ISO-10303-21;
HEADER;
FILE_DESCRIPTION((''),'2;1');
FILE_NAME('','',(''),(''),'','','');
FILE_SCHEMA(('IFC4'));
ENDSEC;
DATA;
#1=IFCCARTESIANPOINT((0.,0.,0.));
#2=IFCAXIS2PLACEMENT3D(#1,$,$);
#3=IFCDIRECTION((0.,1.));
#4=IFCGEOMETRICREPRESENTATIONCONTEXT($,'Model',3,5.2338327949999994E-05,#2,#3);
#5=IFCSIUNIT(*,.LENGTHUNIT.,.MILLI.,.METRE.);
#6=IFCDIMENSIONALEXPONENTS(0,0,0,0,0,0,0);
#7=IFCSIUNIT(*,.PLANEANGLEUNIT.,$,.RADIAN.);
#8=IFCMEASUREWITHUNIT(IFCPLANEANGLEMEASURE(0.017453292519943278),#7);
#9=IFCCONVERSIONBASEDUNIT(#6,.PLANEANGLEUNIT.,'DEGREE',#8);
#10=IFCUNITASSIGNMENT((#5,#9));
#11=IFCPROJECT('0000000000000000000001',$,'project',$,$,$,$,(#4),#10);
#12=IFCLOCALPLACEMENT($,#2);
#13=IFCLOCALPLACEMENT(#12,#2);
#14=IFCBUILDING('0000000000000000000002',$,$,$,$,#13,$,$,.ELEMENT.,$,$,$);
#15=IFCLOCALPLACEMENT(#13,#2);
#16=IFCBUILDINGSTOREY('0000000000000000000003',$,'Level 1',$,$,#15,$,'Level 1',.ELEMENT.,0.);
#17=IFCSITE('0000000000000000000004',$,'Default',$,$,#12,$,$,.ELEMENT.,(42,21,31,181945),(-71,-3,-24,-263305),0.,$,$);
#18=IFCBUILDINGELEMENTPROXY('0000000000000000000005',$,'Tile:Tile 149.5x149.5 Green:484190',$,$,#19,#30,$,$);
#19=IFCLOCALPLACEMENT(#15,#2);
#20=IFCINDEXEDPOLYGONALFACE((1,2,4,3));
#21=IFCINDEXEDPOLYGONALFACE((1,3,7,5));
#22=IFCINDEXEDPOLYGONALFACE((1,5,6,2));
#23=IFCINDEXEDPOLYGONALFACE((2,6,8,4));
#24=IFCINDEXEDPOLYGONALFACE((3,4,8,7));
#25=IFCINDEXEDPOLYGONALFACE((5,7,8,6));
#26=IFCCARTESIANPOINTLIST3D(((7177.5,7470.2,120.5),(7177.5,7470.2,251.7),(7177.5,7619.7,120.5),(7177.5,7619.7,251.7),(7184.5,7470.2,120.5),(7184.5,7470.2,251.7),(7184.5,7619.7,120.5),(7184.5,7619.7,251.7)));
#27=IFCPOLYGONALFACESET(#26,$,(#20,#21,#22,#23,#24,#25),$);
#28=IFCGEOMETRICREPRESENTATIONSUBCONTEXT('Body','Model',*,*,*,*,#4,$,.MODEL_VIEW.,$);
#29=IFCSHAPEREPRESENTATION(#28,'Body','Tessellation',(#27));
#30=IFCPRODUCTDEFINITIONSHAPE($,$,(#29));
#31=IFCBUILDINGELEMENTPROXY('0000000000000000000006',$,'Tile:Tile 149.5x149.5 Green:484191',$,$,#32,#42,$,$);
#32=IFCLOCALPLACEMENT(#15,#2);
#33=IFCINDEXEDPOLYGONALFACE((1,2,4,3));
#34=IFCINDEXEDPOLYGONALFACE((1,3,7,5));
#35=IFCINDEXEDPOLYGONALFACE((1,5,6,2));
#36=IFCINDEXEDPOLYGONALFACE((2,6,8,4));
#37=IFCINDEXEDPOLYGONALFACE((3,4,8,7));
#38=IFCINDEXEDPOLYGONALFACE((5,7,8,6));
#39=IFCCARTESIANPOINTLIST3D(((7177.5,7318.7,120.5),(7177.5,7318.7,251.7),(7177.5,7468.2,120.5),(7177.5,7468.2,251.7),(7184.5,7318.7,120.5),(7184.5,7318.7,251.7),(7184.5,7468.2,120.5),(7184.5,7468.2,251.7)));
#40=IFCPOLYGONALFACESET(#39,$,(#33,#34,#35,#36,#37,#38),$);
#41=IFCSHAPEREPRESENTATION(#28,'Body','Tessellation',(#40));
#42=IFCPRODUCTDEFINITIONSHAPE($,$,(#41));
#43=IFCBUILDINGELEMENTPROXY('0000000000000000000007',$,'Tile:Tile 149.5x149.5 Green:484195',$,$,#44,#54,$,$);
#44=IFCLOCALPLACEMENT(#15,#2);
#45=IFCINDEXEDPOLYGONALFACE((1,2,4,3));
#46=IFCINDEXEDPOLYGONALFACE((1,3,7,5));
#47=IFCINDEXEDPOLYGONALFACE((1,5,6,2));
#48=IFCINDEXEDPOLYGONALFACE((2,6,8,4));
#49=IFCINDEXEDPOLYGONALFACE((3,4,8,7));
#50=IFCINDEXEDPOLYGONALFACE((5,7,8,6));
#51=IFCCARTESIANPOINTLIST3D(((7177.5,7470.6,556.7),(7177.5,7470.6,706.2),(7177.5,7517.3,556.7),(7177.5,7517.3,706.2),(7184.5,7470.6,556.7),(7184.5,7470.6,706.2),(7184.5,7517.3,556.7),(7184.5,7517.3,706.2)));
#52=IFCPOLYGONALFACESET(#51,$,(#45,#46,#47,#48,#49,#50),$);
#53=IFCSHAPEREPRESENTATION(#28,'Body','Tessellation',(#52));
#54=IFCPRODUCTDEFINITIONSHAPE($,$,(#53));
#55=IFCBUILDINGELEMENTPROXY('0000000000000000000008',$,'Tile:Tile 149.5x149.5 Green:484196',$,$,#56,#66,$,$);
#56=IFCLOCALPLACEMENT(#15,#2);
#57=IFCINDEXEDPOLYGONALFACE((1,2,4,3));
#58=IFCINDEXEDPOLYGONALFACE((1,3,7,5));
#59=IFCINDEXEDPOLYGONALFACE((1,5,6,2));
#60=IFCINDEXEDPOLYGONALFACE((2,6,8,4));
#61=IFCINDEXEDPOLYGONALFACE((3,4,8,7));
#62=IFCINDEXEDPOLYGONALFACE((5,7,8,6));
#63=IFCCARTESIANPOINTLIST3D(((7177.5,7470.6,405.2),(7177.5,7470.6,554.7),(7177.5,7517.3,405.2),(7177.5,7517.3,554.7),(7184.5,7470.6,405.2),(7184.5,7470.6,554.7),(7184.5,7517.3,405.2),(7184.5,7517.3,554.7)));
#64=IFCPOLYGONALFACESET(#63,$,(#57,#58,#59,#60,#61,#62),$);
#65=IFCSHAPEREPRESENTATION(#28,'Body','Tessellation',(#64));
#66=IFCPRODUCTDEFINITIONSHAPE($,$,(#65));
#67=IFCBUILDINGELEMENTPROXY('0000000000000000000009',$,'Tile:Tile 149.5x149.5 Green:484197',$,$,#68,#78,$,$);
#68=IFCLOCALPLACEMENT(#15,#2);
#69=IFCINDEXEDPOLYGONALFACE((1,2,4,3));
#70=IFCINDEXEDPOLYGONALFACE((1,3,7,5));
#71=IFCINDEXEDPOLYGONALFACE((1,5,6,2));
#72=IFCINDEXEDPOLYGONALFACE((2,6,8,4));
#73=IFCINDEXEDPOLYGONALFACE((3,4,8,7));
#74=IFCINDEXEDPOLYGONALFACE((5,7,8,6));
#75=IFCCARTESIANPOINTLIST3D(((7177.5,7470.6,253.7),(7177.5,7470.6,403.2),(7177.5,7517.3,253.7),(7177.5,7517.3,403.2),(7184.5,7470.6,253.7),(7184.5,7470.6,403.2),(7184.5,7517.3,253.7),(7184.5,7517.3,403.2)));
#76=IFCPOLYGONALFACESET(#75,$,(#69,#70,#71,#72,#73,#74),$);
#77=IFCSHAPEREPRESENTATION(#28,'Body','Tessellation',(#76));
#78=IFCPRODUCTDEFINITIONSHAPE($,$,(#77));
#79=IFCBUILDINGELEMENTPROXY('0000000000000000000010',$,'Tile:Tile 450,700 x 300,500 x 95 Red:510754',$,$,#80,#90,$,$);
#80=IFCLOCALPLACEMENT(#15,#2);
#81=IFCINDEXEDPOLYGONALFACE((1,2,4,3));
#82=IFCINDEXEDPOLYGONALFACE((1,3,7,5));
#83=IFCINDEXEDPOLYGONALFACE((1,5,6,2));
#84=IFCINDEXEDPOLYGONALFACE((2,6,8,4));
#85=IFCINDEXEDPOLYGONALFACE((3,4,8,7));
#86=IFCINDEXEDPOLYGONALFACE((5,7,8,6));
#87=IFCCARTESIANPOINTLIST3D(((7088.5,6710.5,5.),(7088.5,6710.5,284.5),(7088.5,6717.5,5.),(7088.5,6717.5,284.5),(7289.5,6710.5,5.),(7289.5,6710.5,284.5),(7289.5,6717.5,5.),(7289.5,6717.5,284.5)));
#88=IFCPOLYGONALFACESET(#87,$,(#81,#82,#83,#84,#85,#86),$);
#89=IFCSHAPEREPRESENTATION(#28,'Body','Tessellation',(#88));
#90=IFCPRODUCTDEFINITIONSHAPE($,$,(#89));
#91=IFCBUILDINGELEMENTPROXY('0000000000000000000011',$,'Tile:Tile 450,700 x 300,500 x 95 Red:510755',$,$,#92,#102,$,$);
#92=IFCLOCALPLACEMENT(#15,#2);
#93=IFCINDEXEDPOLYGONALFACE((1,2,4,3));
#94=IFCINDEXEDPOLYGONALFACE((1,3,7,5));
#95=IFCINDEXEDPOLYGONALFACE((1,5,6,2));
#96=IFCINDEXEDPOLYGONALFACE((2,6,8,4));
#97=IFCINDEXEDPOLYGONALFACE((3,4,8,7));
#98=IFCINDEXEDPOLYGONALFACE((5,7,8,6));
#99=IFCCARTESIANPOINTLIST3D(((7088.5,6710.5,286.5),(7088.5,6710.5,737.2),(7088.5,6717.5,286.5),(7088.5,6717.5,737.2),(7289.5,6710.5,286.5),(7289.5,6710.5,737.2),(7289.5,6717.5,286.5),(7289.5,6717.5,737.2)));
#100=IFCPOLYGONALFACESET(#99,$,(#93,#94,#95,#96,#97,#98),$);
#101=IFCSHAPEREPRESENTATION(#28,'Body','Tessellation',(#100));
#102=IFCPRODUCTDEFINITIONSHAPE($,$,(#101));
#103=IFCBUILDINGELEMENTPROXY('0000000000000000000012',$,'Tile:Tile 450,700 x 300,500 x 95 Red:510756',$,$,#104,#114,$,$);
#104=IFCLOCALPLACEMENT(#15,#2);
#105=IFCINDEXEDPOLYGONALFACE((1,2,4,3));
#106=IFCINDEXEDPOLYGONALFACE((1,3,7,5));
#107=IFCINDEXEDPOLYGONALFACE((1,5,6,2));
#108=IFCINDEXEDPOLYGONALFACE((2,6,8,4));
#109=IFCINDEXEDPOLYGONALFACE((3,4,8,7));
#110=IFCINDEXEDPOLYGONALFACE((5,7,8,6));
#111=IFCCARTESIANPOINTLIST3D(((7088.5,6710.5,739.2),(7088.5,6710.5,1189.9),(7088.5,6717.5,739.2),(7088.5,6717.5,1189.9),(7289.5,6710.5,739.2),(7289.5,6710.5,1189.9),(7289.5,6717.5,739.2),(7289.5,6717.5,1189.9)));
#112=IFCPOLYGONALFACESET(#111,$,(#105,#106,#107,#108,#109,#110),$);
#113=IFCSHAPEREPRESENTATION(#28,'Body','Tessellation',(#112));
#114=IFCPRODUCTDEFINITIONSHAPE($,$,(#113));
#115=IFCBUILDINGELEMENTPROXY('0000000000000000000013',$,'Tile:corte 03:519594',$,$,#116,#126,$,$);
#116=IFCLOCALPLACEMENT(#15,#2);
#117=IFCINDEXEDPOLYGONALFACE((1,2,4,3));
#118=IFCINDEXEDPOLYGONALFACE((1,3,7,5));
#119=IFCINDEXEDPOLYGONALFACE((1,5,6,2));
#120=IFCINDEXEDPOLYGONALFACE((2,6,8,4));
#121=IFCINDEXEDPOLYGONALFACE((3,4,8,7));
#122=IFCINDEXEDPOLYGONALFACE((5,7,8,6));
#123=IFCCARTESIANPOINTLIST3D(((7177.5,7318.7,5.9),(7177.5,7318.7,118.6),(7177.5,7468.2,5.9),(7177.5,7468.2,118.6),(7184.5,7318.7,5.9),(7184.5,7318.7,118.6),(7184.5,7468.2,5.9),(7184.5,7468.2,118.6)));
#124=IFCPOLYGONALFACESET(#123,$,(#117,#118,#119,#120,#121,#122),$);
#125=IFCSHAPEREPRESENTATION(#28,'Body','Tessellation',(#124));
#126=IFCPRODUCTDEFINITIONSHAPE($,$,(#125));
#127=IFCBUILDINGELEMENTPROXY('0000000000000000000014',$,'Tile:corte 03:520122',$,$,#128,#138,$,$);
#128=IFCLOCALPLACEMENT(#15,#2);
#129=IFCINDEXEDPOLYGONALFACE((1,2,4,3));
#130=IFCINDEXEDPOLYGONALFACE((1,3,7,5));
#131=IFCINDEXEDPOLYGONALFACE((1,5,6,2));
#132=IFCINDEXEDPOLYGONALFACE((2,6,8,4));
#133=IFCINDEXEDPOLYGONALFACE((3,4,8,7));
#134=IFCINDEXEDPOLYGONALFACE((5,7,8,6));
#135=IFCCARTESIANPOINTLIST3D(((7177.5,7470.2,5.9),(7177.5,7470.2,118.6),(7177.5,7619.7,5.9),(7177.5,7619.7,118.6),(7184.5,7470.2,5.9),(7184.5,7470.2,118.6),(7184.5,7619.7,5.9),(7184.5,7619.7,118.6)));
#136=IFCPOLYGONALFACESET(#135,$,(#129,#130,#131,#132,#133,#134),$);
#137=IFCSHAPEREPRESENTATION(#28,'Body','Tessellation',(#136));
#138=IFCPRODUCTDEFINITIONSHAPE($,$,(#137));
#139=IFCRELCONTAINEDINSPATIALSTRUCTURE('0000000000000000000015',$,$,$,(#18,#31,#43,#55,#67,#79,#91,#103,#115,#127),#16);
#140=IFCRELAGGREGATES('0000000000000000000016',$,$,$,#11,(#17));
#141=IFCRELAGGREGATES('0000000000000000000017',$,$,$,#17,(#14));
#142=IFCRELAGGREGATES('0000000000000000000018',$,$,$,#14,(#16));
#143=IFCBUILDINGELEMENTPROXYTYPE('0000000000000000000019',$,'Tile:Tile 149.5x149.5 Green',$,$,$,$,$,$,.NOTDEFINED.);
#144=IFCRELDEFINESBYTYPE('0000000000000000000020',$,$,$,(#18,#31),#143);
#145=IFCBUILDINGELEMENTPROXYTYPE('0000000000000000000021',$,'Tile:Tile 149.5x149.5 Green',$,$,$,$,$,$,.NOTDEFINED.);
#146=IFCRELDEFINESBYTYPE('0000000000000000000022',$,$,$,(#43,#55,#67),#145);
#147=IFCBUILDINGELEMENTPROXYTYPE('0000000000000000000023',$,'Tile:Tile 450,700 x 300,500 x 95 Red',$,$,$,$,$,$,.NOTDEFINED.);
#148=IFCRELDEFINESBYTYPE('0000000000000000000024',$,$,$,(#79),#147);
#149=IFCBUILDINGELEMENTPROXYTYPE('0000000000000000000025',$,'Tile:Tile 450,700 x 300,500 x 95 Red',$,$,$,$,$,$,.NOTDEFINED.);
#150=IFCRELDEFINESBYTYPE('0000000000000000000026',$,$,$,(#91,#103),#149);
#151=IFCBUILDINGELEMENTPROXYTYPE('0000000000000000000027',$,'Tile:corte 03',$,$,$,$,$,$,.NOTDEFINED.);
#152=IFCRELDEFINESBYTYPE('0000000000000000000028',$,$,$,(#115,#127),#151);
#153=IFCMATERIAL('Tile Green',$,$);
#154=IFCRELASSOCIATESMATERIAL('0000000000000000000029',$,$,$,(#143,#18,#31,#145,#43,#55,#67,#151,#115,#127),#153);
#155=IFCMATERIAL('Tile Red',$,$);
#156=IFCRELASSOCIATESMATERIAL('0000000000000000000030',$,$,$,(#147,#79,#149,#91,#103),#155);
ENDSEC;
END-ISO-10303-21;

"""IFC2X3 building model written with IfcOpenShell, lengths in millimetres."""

from ifc_helpers import new_model, entity, si_unit, converted_unit, direction, frame, frame_2d, origin, origin_2d_with_axis, place, context, subcontext, project, spatial, rectangle, extrude, source, transform, mapped, material, type_object, type_shapes, element, save


model = new_model("IFC2X3")

# Units and contexts
model_context = context("Model", 3, precision=5.2338327949999994e-05, world=origin(), true_north=direction((0.0, 1.0)))
body_context = subcontext(model_context, "Body", "Model", "MODEL_VIEW")
ifc_project = project(units=[si_unit("LENGTHUNIT", "METRE", prefix="MILLI"), converted_unit("PLANEANGLEUNIT", "DEGREE", entity("IfcPlaneAngleMeasure", 0.017453292519943278), si_unit("PLANEANGLEUNIT", "RADIAN"), dimensions=[0, 0, 0, 0, 0, 0, 0])], contexts=[model_context])

# Site, building, storey
site_placement = place(None, origin())
site = spatial("IfcSite", under=ifc_project, at=site_placement, Name="Default", CompositionType="ELEMENT", RefLatitude=(42, 21, 31, 181945), RefLongitude=(-71, -3, -24, -263305), RefElevation=0.0)
building_placement = place(site_placement, origin())
building = spatial("IfcBuilding", under=site, at=building_placement, CompositionType="ELEMENT")
storey_placement = place(building_placement, origin())
storey = spatial("IfcBuildingStorey", under=building, at=storey_placement, Name="Level 1", LongName="Level 1", CompositionType="ELEMENT", Elevation=0.0)

# Building element proxies
ifc_material_1 = material(Name="Tile Red")
ifc_material_2 = material(Name="Tile Green")
building_element_proxy_type_1 = type_object("IfcBuildingElementProxyType", Name="Tile:Tile 149.5x149.5 Green", PredefinedType="NOTDEFINED", material=ifc_material_2)
shared_shape_1 = source(origin(), body_context, "Body", "SweptSolid", [
    extrude(rectangle(XDim=131.2, YDim=149.5, at=origin_2d_with_axis()), frame((-65.6, -74.8, 0.0), z_axis=(0.0, 0.0, 1.0), x_axis=(-1.0, 0.0, 0.0)), (0.0, 0.0, 1.0), 7.0),
])
type_shapes(building_element_proxy_type_1, [shared_shape_1])
for number, where, z_axis, x_axis, name in (
    (1, (7184.5, 7619.7, 251.7), (-1.0, 0.0, 0.0), (0.0, 0.0, 1.0), "Tile:Tile 149.5x149.5 Green:484190"),
    (2, (7184.5, 7468.2, 251.7), (-1.0, 0.0, 0.0), (0.0, 0.0, 1.0), "Tile:Tile 149.5x149.5 Green:484191"),
):
    element("IfcBuildingElementProxy", number, at=place(storey_placement, frame(where, z_axis=z_axis, x_axis=x_axis)), inside=storey, type_object=building_element_proxy_type_1, material=ifc_material_2, Name=name, context=body_context, shape_type="MappedRepresentation", body=[
        mapped(shared_shape_1, transform((0.0, 0.0, 0.0), scale=1.0)),
    ])
building_element_proxy_type_2 = type_object("IfcBuildingElementProxyType", Name="Tile:Tile 149.5x149.5 Green", PredefinedType="NOTDEFINED", material=ifc_material_2)
shared_shape_2 = source(origin(), body_context, "Body", "SweptSolid", [
    extrude(rectangle(XDim=46.7, YDim=149.5, at=origin_2d_with_axis()), frame((-23.3, -74.8, 0.0), z_axis=(0.0, 0.0, 1.0), x_axis=(-1.0, 0.0, 0.0)), (0.0, 0.0, 1.0), 7.0),
])
type_shapes(building_element_proxy_type_2, [shared_shape_2])
for number, where, z_axis, x_axis, name in (
    (3, (7184.5, 7517.3, 556.7), (-1.0, 0.0, 0.0), (0.0, 1.0, 0.0), "Tile:Tile 149.5x149.5 Green:484195"),
    (4, (7184.5, 7517.3, 405.2), (-1.0, 0.0, 0.0), (0.0, 1.0, 0.0), "Tile:Tile 149.5x149.5 Green:484196"),
    (5, (7184.5, 7517.3, 253.7), (-1.0, 0.0, 0.0), (0.0, 1.0, 0.0), "Tile:Tile 149.5x149.5 Green:484197"),
):
    element("IfcBuildingElementProxy", number, at=place(storey_placement, frame(where, z_axis=z_axis, x_axis=x_axis)), inside=storey, type_object=building_element_proxy_type_2, material=ifc_material_2, Name=name, context=body_context, shape_type="MappedRepresentation", body=[
        mapped(shared_shape_2, transform((0.0, 0.0, 0.0), scale=1.0)),
    ])
building_element_proxy_type_3 = type_object("IfcBuildingElementProxyType", Name="Tile:Tile 450,700 x 300,500 x 95 Red", PredefinedType="NOTDEFINED", material=ifc_material_1)
shared_shape_3 = source(origin(), body_context, "Body", "SweptSolid", [
    extrude(rectangle(XDim=201.0, YDim=279.5, at=frame_2d((0.0, 0.0), x_axis=(1.0, 0.0))), frame((-100.5, -139.7, 0.0), z_axis=(0.0, 0.0, 1.0), x_axis=(-1.0, 0.0, 0.0)), (0.0, 0.0, 1.0), 7.0),
])
type_shapes(building_element_proxy_type_3, [shared_shape_3])
proxy_1_placement = place(storey_placement, frame((7088.5, 6717.5, 5.0), z_axis=(0.0, -1.0, 0.0), x_axis=(-1.0, 0.0, 0.0)))
element("IfcBuildingElementProxy", 6, at=proxy_1_placement, inside=storey, type_object=building_element_proxy_type_3, material=ifc_material_1, Name="Tile:Tile 450,700 x 300,500 x 95 Red:510754", context=body_context, shape_type="MappedRepresentation", body=[
    mapped(shared_shape_3, transform((0.0, 0.0, 0.0), scale=1.0)),
])
building_element_proxy_type_4 = type_object("IfcBuildingElementProxyType", Name="Tile:Tile 450,700 x 300,500 x 95 Red", PredefinedType="NOTDEFINED", material=ifc_material_1)
shared_shape_4 = source(origin(), body_context, "Body", "SweptSolid", [
    extrude(rectangle(XDim=201.0, YDim=450.7, at=frame_2d((0.0, 0.0), x_axis=(1.0, 0.0))), frame((-100.5, -225.4, 0.0), z_axis=(0.0, 0.0, 1.0), x_axis=(-1.0, 0.0, 0.0)), (0.0, 0.0, 1.0), 7.0),
])
type_shapes(building_element_proxy_type_4, [shared_shape_4])
for number, where, z_axis, x_axis, name in (
    (7, (7088.5, 6717.5, 286.5), (0.0, -1.0, 0.0), (-1.0, 0.0, 0.0), "Tile:Tile 450,700 x 300,500 x 95 Red:510755"),
    (8, (7088.5, 6717.5, 739.2), (0.0, -1.0, 0.0), (-1.0, 0.0, 0.0), "Tile:Tile 450,700 x 300,500 x 95 Red:510756"),
):
    element("IfcBuildingElementProxy", number, at=place(storey_placement, frame(where, z_axis=z_axis, x_axis=x_axis)), inside=storey, type_object=building_element_proxy_type_4, material=ifc_material_1, Name=name, context=body_context, shape_type="MappedRepresentation", body=[
        mapped(shared_shape_4, transform((0.0, 0.0, 0.0), scale=1.0)),
    ])
building_element_proxy_type_5 = type_object("IfcBuildingElementProxyType", Name="Tile:corte 03", PredefinedType="NOTDEFINED", material=ifc_material_2)
shared_shape_5 = source(origin(), body_context, "Body", "SweptSolid", [
    extrude(rectangle(XDim=112.7, YDim=149.5, at=origin_2d_with_axis()), frame((-56.3, -74.8, 0.0), z_axis=(0.0, 0.0, 1.0), x_axis=(-1.0, 0.0, 0.0)), (0.0, 0.0, 1.0), 7.0),
])
type_shapes(building_element_proxy_type_5, [shared_shape_5])
for number, where, z_axis, x_axis, name in (
    (9, (7184.5, 7468.2, 118.6), (-1.0, 0.0, 0.0), (0.0, 0.0, 1.0), "Tile:corte 03:519594"),
    (10, (7184.5, 7619.7, 118.6), (-1.0, 0.0, 0.0), (0.0, 0.0, 1.0), "Tile:corte 03:520122"),
):
    element("IfcBuildingElementProxy", number, at=place(storey_placement, frame(where, z_axis=z_axis, x_axis=x_axis)), inside=storey, type_object=building_element_proxy_type_5, material=ifc_material_2, Name=name, context=body_context, shape_type="MappedRepresentation", body=[
        mapped(shared_shape_5, transform((0.0, 0.0, 0.0), scale=1.0)),
    ])

save(model, "model.ifc")
